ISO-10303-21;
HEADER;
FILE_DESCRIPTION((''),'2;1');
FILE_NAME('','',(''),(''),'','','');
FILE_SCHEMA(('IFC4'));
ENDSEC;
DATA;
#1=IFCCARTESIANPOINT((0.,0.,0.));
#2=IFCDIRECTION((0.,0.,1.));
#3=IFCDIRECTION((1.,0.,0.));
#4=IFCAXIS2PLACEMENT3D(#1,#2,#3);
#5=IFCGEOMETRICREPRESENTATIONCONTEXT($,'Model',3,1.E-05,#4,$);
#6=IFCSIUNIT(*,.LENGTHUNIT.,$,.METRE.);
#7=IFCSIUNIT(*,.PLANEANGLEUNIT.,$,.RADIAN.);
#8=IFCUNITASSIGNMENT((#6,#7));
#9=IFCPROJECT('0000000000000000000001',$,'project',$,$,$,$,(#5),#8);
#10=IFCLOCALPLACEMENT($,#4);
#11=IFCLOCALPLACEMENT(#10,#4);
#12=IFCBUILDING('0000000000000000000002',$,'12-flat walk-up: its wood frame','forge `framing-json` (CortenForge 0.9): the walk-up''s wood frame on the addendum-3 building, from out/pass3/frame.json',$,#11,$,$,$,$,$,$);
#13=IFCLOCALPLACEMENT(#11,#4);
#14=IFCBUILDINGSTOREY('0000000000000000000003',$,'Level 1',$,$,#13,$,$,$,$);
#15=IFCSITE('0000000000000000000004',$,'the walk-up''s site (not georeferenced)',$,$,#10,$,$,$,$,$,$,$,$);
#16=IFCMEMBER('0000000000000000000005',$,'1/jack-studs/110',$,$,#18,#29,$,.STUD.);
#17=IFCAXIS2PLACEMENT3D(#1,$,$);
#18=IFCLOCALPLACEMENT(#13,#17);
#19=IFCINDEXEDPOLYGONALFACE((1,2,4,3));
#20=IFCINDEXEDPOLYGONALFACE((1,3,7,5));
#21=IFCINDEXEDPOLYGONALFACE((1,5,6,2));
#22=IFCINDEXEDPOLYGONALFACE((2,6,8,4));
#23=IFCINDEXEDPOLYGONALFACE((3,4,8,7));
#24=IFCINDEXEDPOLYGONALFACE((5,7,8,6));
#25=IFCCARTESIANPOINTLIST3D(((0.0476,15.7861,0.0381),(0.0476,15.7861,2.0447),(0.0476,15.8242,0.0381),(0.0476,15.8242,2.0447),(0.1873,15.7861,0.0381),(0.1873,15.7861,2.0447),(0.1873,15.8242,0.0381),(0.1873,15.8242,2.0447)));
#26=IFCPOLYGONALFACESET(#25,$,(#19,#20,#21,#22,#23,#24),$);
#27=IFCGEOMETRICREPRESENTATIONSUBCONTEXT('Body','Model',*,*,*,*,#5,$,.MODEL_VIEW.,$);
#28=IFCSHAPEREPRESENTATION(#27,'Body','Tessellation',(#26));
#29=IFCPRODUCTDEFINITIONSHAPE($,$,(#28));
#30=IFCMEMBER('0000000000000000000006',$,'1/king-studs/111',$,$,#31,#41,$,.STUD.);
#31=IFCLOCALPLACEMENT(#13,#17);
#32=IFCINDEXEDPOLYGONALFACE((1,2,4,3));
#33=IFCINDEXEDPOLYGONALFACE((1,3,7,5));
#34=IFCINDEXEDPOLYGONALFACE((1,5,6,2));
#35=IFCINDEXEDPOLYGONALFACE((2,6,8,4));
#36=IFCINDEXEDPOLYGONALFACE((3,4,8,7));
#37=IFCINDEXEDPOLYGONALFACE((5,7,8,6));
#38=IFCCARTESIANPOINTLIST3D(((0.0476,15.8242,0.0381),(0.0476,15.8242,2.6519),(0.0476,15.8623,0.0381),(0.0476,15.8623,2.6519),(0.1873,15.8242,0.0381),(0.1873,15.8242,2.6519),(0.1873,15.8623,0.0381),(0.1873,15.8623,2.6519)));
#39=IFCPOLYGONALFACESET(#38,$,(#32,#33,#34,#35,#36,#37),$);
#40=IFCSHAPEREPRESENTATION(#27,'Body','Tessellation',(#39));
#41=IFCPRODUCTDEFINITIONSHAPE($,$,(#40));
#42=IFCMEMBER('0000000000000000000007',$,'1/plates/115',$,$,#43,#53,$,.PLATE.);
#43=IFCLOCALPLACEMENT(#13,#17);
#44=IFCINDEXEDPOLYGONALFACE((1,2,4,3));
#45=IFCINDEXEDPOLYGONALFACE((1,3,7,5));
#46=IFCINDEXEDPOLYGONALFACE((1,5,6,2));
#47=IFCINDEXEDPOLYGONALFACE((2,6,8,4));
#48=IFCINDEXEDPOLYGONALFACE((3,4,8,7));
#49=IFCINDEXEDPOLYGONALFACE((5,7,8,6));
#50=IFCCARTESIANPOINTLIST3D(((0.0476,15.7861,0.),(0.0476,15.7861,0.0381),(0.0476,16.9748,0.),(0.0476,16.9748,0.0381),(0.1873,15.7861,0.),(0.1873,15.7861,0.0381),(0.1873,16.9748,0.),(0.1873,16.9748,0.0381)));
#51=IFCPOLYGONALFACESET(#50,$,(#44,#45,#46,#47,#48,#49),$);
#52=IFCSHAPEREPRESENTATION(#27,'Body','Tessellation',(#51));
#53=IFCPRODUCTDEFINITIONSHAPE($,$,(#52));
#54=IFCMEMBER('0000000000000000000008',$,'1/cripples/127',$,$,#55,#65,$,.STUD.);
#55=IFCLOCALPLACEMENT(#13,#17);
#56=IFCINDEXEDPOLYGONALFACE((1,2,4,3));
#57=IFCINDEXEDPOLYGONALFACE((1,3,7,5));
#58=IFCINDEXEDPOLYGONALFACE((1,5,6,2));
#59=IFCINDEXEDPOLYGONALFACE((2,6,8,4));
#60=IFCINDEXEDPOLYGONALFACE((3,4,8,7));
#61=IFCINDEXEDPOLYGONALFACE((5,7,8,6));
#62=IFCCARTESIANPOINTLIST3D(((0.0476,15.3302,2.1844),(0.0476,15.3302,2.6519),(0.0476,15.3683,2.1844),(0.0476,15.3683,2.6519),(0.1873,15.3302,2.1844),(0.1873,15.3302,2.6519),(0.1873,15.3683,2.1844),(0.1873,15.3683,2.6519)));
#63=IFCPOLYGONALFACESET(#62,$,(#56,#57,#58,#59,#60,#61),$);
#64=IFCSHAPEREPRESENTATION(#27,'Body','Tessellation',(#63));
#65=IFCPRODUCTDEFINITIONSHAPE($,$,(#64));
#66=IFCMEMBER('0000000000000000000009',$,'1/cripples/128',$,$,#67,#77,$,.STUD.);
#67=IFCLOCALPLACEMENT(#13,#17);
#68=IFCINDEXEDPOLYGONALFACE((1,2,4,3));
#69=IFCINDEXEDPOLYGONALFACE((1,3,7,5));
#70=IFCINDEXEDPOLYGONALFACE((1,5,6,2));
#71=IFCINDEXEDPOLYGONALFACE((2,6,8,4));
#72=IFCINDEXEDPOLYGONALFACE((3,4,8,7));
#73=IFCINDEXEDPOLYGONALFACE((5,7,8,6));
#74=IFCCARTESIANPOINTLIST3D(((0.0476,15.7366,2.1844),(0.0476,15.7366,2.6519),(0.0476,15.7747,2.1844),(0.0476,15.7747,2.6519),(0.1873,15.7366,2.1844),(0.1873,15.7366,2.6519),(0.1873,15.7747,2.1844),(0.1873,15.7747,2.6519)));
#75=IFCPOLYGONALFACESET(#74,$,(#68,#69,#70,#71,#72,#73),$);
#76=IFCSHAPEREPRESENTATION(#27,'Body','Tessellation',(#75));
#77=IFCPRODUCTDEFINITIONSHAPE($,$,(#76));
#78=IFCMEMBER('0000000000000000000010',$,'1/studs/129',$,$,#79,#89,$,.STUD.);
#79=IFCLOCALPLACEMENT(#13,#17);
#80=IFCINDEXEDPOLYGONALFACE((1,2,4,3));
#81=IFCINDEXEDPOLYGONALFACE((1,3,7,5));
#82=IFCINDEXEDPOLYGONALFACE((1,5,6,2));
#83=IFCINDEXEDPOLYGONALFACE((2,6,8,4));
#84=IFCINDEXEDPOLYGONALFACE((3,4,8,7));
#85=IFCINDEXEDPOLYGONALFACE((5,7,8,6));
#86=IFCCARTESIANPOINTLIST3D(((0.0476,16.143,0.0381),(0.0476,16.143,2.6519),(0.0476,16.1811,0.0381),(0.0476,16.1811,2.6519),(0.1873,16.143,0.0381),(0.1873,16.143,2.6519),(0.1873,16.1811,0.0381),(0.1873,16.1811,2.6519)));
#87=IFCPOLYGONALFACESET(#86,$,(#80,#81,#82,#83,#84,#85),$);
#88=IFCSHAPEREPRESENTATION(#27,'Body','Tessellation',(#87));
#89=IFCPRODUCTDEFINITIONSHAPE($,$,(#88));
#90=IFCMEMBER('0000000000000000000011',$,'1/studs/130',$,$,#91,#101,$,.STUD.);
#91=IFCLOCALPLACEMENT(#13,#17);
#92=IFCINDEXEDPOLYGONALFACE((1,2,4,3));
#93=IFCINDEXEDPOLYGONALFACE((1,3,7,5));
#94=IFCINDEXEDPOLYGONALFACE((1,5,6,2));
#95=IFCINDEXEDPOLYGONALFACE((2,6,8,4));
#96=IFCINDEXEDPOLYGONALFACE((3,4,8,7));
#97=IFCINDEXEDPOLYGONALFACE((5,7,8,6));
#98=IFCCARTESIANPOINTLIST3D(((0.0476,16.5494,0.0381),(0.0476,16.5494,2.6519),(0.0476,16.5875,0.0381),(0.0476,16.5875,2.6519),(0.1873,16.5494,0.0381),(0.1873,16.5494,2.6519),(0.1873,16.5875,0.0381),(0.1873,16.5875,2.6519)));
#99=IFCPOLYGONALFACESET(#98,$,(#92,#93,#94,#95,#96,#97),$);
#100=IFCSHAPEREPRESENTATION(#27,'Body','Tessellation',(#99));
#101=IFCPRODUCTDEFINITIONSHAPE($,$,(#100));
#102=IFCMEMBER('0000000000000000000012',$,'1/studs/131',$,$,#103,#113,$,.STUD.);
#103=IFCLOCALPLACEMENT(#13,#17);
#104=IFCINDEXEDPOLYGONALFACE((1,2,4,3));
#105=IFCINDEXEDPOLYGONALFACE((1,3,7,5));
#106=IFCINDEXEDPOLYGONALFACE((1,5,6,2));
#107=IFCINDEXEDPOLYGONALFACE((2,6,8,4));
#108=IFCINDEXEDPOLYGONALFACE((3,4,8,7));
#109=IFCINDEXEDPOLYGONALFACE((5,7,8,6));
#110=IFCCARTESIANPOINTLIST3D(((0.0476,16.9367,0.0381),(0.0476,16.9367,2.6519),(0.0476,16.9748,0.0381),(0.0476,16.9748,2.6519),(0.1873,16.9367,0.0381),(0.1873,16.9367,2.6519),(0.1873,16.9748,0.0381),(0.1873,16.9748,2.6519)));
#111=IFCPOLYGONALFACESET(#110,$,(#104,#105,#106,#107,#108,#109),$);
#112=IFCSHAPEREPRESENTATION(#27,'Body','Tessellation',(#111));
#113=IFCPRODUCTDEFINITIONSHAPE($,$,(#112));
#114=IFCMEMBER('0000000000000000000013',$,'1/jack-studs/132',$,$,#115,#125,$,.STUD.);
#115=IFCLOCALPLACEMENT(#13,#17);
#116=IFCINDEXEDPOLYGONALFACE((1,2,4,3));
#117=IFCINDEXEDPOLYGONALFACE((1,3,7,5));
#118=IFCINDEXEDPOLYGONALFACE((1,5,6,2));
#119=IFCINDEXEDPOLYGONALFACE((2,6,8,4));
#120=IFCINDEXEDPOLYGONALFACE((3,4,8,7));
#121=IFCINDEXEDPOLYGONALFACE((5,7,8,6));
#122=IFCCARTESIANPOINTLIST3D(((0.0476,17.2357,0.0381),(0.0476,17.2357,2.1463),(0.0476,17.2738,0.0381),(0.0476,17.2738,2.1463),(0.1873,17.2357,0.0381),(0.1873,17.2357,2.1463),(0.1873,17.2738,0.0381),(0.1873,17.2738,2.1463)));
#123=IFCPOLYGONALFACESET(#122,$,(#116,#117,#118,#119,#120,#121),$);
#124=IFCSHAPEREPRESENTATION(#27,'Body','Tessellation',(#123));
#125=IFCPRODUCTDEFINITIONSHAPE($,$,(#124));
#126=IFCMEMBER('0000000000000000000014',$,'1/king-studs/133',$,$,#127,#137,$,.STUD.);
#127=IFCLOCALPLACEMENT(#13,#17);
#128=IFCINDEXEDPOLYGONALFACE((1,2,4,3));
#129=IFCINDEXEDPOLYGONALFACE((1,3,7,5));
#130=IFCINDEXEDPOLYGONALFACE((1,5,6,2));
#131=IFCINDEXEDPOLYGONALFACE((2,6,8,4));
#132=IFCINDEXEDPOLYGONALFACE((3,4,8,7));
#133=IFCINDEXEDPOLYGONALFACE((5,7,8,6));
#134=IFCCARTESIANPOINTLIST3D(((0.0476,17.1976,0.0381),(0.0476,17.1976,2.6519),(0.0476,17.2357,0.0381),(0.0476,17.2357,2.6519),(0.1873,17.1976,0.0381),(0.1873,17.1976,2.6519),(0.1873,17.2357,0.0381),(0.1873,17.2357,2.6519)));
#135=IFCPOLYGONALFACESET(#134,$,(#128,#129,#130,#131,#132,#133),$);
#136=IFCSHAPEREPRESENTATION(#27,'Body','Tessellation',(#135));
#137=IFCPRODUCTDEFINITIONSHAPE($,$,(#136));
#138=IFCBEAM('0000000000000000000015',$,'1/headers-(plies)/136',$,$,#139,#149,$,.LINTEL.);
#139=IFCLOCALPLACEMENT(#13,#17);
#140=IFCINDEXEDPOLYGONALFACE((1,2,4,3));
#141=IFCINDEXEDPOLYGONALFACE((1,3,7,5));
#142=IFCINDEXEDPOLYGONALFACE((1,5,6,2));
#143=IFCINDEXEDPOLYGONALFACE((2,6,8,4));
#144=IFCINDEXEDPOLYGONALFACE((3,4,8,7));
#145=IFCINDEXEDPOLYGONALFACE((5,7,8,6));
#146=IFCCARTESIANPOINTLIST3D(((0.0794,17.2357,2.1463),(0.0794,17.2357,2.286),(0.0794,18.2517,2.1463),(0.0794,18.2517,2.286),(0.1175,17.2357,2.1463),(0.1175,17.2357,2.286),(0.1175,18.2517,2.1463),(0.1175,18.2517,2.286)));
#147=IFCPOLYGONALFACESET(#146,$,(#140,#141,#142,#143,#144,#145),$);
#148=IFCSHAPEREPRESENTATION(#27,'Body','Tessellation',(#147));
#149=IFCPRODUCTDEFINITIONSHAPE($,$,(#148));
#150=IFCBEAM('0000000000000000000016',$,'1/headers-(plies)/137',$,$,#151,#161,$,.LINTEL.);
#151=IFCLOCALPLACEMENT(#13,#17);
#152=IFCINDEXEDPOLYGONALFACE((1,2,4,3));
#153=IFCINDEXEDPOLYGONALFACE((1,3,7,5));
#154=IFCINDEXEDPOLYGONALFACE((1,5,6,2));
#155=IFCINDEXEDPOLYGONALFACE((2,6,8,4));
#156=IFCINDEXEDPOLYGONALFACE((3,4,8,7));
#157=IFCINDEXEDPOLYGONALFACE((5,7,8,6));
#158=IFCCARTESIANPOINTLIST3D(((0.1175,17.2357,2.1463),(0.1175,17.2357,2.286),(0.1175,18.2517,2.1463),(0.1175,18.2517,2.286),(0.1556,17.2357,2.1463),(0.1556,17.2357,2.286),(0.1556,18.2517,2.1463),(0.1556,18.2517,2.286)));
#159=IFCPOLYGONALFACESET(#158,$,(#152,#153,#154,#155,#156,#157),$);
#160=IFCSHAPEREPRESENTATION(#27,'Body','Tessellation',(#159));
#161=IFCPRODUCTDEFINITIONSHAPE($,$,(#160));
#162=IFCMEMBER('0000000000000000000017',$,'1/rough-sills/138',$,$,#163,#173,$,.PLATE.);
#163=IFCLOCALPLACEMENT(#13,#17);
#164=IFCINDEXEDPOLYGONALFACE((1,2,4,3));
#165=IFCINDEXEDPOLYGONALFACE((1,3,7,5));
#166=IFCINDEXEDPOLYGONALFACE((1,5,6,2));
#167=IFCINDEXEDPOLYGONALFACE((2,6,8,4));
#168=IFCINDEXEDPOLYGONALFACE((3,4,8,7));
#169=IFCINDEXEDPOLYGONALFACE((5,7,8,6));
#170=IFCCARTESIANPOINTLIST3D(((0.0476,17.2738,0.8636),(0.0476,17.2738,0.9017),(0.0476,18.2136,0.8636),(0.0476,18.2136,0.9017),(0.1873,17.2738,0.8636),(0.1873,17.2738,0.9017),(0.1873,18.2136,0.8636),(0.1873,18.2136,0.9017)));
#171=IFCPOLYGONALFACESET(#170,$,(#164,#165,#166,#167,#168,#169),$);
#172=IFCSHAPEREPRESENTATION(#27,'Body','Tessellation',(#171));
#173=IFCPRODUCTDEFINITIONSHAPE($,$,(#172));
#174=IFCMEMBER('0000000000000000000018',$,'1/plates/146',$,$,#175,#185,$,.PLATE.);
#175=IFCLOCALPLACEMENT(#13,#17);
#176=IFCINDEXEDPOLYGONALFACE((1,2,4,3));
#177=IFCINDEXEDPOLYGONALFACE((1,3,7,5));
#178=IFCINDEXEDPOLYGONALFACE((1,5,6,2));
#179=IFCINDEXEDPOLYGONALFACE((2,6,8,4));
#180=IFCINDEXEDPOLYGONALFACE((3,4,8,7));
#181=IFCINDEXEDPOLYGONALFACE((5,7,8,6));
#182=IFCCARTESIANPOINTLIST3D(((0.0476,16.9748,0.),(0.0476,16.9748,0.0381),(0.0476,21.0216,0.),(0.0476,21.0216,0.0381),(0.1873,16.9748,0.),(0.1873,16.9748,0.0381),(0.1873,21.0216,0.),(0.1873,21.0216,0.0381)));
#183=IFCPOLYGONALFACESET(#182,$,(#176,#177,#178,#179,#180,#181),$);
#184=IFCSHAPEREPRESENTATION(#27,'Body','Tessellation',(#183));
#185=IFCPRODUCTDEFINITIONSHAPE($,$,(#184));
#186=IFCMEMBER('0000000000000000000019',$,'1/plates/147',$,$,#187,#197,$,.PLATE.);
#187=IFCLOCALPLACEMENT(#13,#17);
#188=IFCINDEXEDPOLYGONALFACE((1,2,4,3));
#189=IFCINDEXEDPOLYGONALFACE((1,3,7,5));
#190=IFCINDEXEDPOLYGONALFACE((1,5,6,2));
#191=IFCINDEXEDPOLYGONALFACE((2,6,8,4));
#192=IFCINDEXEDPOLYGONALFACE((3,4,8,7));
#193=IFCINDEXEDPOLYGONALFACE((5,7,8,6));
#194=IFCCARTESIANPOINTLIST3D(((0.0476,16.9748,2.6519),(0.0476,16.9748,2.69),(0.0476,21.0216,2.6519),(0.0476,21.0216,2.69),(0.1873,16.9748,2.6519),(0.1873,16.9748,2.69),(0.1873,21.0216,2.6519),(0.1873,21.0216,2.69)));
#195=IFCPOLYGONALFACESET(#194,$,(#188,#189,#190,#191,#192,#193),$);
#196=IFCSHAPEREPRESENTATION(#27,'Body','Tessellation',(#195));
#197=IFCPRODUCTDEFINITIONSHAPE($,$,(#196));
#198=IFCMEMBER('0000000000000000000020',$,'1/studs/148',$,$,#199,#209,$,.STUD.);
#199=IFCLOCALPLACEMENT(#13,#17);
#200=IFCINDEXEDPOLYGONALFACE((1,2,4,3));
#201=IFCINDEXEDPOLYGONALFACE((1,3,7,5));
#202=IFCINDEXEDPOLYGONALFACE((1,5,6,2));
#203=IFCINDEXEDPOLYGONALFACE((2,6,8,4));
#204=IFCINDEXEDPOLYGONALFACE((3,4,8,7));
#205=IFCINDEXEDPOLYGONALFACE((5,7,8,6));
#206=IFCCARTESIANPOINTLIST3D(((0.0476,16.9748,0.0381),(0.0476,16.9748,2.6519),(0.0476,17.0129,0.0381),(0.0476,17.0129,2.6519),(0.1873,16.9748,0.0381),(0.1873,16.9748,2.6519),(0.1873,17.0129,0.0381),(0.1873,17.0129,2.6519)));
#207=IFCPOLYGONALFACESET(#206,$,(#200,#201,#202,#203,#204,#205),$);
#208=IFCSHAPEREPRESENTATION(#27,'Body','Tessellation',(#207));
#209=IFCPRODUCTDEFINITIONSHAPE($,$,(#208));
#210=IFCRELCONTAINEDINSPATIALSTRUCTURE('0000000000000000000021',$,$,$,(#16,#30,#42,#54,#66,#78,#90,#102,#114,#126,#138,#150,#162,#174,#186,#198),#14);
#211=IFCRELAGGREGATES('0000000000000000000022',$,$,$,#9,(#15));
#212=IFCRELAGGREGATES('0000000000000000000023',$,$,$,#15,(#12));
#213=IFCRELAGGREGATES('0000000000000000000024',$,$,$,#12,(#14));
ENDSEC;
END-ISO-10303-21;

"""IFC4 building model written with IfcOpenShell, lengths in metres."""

from ifc_helpers import new_model, si_unit, frame, frame_2d, origin, origin_with_axes, place, context, subcontext, project, spatial, rectangle, extrude, element, save


model = new_model("IFC4")

# Units and contexts
model_context = context("Model", 3, precision=1e-05, world=origin_with_axes())
body_context = subcontext(model_context, "Body", "Model", "MODEL_VIEW")
ifc_project = project(units=[si_unit("LENGTHUNIT", "METRE"), si_unit("PLANEANGLEUNIT", "RADIAN")], contexts=[model_context])

# Site, building, storey
site_placement = place(None, origin_with_axes())
site = spatial("IfcSite", under=ifc_project, at=site_placement, Name="the walk-up's site (not georeferenced)")
building_placement = place(site_placement, origin_with_axes())
building = spatial("IfcBuilding", under=site, at=building_placement, Name="12-flat walk-up: its wood frame", Description="forge `framing-json` (CortenForge 0.9): the walk-up's wood frame on the addendum-3 building, from out/pass3/frame.json")
storey_placement = place(building_placement, origin_with_axes())
storey = spatial("IfcBuildingStorey", under=building, at=storey_placement, Name="Level 1")

# Members
member_1_placement = place(storey_placement, frame((0.0476, 15.7861, 0.0381), z_axis=(0.0, 0.0, 1.0), x_axis=(1.0, 0.0, 0.0)))
element("IfcMember", 1, at=member_1_placement, inside=storey, Name="1/jack-studs/110", PredefinedType="STUD", context=body_context, shape_type="SweptSolid", body=[
    extrude(rectangle(XDim=0.1397, YDim=0.0381, at=frame_2d((0.0698, 0.0191))), origin(), (0.0, 0.0, 1.0), 2.0066),
])
member_2_placement = place(storey_placement, frame((0.0476, 15.8242, 0.0381), z_axis=(0.0, 0.0, 1.0), x_axis=(1.0, 0.0, 0.0)))
element("IfcMember", 2, at=member_2_placement, inside=storey, Name="1/king-studs/111", PredefinedType="STUD", context=body_context, shape_type="SweptSolid", body=[
    extrude(rectangle(XDim=0.1397, YDim=0.0381, at=frame_2d((0.0698, 0.0191))), origin(), (0.0, 0.0, 1.0), 2.6138),
])
member_3_placement = place(storey_placement, frame((0.0476, 15.7861, 0.0), z_axis=(0.0, 0.0, 1.0), x_axis=(1.0, 0.0, 0.0)))
element("IfcMember", 3, at=member_3_placement, inside=storey, Name="1/plates/115", PredefinedType="PLATE", context=body_context, shape_type="SweptSolid", body=[
    extrude(rectangle(XDim=0.1397, YDim=1.1887, at=frame_2d((0.0698, 0.5944))), origin(), (0.0, 0.0, 1.0), 0.0381),
])
for number, where, z_axis, x_axis, name in (
    (4, (0.0476, 15.3302, 2.1844), (0.0, 0.0, 1.0), (1.0, 0.0, 0.0), "1/cripples/127"),
    (5, (0.0476, 15.7366, 2.1844), (0.0, 0.0, 1.0), (1.0, 0.0, 0.0), "1/cripples/128"),
):
    element("IfcMember", number, at=place(storey_placement, frame(where, z_axis=z_axis, x_axis=x_axis)), inside=storey, Name=name, PredefinedType="STUD", context=body_context, shape_type="SweptSolid", body=[
        extrude(rectangle(XDim=0.1397, YDim=0.0381, at=frame_2d((0.0698, 0.0191))), origin(), (0.0, 0.0, 1.0), 0.4675),
    ])
for number, where, z_axis, x_axis, name in (
    (6, (0.0476, 16.143, 0.0381), (0.0, 0.0, 1.0), (1.0, 0.0, 0.0), "1/studs/129"),
    (7, (0.0476, 16.5494, 0.0381), (0.0, 0.0, 1.0), (1.0, 0.0, 0.0), "1/studs/130"),
    (8, (0.0476, 16.9367, 0.0381), (0.0, 0.0, 1.0), (1.0, 0.0, 0.0), "1/studs/131"),
):
    element("IfcMember", number, at=place(storey_placement, frame(where, z_axis=z_axis, x_axis=x_axis)), inside=storey, Name=name, PredefinedType="STUD", context=body_context, shape_type="SweptSolid", body=[
        extrude(rectangle(XDim=0.1397, YDim=0.0381, at=frame_2d((0.0698, 0.0191))), origin(), (0.0, 0.0, 1.0), 2.6138),
    ])
member_4_placement = place(storey_placement, frame((0.0476, 17.2357, 0.0381), z_axis=(0.0, 0.0, 1.0), x_axis=(1.0, 0.0, 0.0)))
element("IfcMember", 9, at=member_4_placement, inside=storey, Name="1/jack-studs/132", PredefinedType="STUD", context=body_context, shape_type="SweptSolid", body=[
    extrude(rectangle(XDim=0.1397, YDim=0.0381, at=frame_2d((0.0698, 0.0191))), origin(), (0.0, 0.0, 1.0), 2.1082),
])
member_5_placement = place(storey_placement, frame((0.0476, 17.1976, 0.0381), z_axis=(0.0, 0.0, 1.0), x_axis=(1.0, 0.0, 0.0)))
element("IfcMember", 10, at=member_5_placement, inside=storey, Name="1/king-studs/133", PredefinedType="STUD", context=body_context, shape_type="SweptSolid", body=[
    extrude(rectangle(XDim=0.1397, YDim=0.0381, at=frame_2d((0.0698, 0.0191))), origin(), (0.0, 0.0, 1.0), 2.6138),
])

# Beams
for number, where, z_axis, x_axis, name in (
    (11, (0.0794, 17.2357, 2.1463), (0.0, 0.0, 1.0), (1.0, 0.0, 0.0), "1/headers-(plies)/136"),
    (12, (0.1175, 17.2357, 2.1463), (0.0, 0.0, 1.0), (1.0, 0.0, 0.0), "1/headers-(plies)/137"),
):
    element("IfcBeam", number, at=place(storey_placement, frame(where, z_axis=z_axis, x_axis=x_axis)), inside=storey, Name=name, PredefinedType="LINTEL", context=body_context, shape_type="SweptSolid", body=[
        extrude(rectangle(XDim=0.0381, YDim=1.016, at=frame_2d((0.019, 0.508))), origin(), (0.0, 0.0, 1.0), 0.1397),
    ])

# Members
member_6_placement = place(storey_placement, frame((0.0476, 17.2738, 0.8636), z_axis=(0.0, 0.0, 1.0), x_axis=(1.0, 0.0, 0.0)))
element("IfcMember", 13, at=member_6_placement, inside=storey, Name="1/rough-sills/138", PredefinedType="PLATE", context=body_context, shape_type="SweptSolid", body=[
    extrude(rectangle(XDim=0.1397, YDim=0.9398, at=frame_2d((0.0698, 0.4699))), origin(), (0.0, 0.0, 1.0), 0.0381),
])
member_7_placement = place(storey_placement, frame((0.0476, 16.9748, 0.0), z_axis=(0.0, 0.0, 1.0), x_axis=(1.0, 0.0, 0.0)))
element("IfcMember", 14, at=member_7_placement, inside=storey, Name="1/plates/146", PredefinedType="PLATE", context=body_context, shape_type="SweptSolid", body=[
    extrude(rectangle(XDim=0.1397, YDim=4.0468, at=frame_2d((0.0698, 2.0234))), origin(), (0.0, 0.0, 1.0), 0.0381),
])
member_8_placement = place(storey_placement, frame((0.0476, 16.9748, 2.6519), z_axis=(0.0, 0.0, 1.0), x_axis=(1.0, 0.0, 0.0)))
element("IfcMember", 15, at=member_8_placement, inside=storey, Name="1/plates/147", PredefinedType="PLATE", context=body_context, shape_type="SweptSolid", body=[
    extrude(rectangle(XDim=0.1397, YDim=4.0468, at=frame_2d((0.0698, 2.0234))), origin(), (0.0, 0.0, 1.0), 0.0381),
])
member_9_placement = place(storey_placement, frame((0.0476, 16.9748, 0.0381), z_axis=(0.0, 0.0, 1.0), x_axis=(1.0, 0.0, 0.0)))
element("IfcMember", 16, at=member_9_placement, inside=storey, Name="1/studs/148", PredefinedType="STUD", context=body_context, shape_type="SweptSolid", body=[
    extrude(rectangle(XDim=0.1397, YDim=0.0381, at=frame_2d((0.0698, 0.0191))), origin(), (0.0, 0.0, 1.0), 2.6138),
])

save(model, "model.ifc")
